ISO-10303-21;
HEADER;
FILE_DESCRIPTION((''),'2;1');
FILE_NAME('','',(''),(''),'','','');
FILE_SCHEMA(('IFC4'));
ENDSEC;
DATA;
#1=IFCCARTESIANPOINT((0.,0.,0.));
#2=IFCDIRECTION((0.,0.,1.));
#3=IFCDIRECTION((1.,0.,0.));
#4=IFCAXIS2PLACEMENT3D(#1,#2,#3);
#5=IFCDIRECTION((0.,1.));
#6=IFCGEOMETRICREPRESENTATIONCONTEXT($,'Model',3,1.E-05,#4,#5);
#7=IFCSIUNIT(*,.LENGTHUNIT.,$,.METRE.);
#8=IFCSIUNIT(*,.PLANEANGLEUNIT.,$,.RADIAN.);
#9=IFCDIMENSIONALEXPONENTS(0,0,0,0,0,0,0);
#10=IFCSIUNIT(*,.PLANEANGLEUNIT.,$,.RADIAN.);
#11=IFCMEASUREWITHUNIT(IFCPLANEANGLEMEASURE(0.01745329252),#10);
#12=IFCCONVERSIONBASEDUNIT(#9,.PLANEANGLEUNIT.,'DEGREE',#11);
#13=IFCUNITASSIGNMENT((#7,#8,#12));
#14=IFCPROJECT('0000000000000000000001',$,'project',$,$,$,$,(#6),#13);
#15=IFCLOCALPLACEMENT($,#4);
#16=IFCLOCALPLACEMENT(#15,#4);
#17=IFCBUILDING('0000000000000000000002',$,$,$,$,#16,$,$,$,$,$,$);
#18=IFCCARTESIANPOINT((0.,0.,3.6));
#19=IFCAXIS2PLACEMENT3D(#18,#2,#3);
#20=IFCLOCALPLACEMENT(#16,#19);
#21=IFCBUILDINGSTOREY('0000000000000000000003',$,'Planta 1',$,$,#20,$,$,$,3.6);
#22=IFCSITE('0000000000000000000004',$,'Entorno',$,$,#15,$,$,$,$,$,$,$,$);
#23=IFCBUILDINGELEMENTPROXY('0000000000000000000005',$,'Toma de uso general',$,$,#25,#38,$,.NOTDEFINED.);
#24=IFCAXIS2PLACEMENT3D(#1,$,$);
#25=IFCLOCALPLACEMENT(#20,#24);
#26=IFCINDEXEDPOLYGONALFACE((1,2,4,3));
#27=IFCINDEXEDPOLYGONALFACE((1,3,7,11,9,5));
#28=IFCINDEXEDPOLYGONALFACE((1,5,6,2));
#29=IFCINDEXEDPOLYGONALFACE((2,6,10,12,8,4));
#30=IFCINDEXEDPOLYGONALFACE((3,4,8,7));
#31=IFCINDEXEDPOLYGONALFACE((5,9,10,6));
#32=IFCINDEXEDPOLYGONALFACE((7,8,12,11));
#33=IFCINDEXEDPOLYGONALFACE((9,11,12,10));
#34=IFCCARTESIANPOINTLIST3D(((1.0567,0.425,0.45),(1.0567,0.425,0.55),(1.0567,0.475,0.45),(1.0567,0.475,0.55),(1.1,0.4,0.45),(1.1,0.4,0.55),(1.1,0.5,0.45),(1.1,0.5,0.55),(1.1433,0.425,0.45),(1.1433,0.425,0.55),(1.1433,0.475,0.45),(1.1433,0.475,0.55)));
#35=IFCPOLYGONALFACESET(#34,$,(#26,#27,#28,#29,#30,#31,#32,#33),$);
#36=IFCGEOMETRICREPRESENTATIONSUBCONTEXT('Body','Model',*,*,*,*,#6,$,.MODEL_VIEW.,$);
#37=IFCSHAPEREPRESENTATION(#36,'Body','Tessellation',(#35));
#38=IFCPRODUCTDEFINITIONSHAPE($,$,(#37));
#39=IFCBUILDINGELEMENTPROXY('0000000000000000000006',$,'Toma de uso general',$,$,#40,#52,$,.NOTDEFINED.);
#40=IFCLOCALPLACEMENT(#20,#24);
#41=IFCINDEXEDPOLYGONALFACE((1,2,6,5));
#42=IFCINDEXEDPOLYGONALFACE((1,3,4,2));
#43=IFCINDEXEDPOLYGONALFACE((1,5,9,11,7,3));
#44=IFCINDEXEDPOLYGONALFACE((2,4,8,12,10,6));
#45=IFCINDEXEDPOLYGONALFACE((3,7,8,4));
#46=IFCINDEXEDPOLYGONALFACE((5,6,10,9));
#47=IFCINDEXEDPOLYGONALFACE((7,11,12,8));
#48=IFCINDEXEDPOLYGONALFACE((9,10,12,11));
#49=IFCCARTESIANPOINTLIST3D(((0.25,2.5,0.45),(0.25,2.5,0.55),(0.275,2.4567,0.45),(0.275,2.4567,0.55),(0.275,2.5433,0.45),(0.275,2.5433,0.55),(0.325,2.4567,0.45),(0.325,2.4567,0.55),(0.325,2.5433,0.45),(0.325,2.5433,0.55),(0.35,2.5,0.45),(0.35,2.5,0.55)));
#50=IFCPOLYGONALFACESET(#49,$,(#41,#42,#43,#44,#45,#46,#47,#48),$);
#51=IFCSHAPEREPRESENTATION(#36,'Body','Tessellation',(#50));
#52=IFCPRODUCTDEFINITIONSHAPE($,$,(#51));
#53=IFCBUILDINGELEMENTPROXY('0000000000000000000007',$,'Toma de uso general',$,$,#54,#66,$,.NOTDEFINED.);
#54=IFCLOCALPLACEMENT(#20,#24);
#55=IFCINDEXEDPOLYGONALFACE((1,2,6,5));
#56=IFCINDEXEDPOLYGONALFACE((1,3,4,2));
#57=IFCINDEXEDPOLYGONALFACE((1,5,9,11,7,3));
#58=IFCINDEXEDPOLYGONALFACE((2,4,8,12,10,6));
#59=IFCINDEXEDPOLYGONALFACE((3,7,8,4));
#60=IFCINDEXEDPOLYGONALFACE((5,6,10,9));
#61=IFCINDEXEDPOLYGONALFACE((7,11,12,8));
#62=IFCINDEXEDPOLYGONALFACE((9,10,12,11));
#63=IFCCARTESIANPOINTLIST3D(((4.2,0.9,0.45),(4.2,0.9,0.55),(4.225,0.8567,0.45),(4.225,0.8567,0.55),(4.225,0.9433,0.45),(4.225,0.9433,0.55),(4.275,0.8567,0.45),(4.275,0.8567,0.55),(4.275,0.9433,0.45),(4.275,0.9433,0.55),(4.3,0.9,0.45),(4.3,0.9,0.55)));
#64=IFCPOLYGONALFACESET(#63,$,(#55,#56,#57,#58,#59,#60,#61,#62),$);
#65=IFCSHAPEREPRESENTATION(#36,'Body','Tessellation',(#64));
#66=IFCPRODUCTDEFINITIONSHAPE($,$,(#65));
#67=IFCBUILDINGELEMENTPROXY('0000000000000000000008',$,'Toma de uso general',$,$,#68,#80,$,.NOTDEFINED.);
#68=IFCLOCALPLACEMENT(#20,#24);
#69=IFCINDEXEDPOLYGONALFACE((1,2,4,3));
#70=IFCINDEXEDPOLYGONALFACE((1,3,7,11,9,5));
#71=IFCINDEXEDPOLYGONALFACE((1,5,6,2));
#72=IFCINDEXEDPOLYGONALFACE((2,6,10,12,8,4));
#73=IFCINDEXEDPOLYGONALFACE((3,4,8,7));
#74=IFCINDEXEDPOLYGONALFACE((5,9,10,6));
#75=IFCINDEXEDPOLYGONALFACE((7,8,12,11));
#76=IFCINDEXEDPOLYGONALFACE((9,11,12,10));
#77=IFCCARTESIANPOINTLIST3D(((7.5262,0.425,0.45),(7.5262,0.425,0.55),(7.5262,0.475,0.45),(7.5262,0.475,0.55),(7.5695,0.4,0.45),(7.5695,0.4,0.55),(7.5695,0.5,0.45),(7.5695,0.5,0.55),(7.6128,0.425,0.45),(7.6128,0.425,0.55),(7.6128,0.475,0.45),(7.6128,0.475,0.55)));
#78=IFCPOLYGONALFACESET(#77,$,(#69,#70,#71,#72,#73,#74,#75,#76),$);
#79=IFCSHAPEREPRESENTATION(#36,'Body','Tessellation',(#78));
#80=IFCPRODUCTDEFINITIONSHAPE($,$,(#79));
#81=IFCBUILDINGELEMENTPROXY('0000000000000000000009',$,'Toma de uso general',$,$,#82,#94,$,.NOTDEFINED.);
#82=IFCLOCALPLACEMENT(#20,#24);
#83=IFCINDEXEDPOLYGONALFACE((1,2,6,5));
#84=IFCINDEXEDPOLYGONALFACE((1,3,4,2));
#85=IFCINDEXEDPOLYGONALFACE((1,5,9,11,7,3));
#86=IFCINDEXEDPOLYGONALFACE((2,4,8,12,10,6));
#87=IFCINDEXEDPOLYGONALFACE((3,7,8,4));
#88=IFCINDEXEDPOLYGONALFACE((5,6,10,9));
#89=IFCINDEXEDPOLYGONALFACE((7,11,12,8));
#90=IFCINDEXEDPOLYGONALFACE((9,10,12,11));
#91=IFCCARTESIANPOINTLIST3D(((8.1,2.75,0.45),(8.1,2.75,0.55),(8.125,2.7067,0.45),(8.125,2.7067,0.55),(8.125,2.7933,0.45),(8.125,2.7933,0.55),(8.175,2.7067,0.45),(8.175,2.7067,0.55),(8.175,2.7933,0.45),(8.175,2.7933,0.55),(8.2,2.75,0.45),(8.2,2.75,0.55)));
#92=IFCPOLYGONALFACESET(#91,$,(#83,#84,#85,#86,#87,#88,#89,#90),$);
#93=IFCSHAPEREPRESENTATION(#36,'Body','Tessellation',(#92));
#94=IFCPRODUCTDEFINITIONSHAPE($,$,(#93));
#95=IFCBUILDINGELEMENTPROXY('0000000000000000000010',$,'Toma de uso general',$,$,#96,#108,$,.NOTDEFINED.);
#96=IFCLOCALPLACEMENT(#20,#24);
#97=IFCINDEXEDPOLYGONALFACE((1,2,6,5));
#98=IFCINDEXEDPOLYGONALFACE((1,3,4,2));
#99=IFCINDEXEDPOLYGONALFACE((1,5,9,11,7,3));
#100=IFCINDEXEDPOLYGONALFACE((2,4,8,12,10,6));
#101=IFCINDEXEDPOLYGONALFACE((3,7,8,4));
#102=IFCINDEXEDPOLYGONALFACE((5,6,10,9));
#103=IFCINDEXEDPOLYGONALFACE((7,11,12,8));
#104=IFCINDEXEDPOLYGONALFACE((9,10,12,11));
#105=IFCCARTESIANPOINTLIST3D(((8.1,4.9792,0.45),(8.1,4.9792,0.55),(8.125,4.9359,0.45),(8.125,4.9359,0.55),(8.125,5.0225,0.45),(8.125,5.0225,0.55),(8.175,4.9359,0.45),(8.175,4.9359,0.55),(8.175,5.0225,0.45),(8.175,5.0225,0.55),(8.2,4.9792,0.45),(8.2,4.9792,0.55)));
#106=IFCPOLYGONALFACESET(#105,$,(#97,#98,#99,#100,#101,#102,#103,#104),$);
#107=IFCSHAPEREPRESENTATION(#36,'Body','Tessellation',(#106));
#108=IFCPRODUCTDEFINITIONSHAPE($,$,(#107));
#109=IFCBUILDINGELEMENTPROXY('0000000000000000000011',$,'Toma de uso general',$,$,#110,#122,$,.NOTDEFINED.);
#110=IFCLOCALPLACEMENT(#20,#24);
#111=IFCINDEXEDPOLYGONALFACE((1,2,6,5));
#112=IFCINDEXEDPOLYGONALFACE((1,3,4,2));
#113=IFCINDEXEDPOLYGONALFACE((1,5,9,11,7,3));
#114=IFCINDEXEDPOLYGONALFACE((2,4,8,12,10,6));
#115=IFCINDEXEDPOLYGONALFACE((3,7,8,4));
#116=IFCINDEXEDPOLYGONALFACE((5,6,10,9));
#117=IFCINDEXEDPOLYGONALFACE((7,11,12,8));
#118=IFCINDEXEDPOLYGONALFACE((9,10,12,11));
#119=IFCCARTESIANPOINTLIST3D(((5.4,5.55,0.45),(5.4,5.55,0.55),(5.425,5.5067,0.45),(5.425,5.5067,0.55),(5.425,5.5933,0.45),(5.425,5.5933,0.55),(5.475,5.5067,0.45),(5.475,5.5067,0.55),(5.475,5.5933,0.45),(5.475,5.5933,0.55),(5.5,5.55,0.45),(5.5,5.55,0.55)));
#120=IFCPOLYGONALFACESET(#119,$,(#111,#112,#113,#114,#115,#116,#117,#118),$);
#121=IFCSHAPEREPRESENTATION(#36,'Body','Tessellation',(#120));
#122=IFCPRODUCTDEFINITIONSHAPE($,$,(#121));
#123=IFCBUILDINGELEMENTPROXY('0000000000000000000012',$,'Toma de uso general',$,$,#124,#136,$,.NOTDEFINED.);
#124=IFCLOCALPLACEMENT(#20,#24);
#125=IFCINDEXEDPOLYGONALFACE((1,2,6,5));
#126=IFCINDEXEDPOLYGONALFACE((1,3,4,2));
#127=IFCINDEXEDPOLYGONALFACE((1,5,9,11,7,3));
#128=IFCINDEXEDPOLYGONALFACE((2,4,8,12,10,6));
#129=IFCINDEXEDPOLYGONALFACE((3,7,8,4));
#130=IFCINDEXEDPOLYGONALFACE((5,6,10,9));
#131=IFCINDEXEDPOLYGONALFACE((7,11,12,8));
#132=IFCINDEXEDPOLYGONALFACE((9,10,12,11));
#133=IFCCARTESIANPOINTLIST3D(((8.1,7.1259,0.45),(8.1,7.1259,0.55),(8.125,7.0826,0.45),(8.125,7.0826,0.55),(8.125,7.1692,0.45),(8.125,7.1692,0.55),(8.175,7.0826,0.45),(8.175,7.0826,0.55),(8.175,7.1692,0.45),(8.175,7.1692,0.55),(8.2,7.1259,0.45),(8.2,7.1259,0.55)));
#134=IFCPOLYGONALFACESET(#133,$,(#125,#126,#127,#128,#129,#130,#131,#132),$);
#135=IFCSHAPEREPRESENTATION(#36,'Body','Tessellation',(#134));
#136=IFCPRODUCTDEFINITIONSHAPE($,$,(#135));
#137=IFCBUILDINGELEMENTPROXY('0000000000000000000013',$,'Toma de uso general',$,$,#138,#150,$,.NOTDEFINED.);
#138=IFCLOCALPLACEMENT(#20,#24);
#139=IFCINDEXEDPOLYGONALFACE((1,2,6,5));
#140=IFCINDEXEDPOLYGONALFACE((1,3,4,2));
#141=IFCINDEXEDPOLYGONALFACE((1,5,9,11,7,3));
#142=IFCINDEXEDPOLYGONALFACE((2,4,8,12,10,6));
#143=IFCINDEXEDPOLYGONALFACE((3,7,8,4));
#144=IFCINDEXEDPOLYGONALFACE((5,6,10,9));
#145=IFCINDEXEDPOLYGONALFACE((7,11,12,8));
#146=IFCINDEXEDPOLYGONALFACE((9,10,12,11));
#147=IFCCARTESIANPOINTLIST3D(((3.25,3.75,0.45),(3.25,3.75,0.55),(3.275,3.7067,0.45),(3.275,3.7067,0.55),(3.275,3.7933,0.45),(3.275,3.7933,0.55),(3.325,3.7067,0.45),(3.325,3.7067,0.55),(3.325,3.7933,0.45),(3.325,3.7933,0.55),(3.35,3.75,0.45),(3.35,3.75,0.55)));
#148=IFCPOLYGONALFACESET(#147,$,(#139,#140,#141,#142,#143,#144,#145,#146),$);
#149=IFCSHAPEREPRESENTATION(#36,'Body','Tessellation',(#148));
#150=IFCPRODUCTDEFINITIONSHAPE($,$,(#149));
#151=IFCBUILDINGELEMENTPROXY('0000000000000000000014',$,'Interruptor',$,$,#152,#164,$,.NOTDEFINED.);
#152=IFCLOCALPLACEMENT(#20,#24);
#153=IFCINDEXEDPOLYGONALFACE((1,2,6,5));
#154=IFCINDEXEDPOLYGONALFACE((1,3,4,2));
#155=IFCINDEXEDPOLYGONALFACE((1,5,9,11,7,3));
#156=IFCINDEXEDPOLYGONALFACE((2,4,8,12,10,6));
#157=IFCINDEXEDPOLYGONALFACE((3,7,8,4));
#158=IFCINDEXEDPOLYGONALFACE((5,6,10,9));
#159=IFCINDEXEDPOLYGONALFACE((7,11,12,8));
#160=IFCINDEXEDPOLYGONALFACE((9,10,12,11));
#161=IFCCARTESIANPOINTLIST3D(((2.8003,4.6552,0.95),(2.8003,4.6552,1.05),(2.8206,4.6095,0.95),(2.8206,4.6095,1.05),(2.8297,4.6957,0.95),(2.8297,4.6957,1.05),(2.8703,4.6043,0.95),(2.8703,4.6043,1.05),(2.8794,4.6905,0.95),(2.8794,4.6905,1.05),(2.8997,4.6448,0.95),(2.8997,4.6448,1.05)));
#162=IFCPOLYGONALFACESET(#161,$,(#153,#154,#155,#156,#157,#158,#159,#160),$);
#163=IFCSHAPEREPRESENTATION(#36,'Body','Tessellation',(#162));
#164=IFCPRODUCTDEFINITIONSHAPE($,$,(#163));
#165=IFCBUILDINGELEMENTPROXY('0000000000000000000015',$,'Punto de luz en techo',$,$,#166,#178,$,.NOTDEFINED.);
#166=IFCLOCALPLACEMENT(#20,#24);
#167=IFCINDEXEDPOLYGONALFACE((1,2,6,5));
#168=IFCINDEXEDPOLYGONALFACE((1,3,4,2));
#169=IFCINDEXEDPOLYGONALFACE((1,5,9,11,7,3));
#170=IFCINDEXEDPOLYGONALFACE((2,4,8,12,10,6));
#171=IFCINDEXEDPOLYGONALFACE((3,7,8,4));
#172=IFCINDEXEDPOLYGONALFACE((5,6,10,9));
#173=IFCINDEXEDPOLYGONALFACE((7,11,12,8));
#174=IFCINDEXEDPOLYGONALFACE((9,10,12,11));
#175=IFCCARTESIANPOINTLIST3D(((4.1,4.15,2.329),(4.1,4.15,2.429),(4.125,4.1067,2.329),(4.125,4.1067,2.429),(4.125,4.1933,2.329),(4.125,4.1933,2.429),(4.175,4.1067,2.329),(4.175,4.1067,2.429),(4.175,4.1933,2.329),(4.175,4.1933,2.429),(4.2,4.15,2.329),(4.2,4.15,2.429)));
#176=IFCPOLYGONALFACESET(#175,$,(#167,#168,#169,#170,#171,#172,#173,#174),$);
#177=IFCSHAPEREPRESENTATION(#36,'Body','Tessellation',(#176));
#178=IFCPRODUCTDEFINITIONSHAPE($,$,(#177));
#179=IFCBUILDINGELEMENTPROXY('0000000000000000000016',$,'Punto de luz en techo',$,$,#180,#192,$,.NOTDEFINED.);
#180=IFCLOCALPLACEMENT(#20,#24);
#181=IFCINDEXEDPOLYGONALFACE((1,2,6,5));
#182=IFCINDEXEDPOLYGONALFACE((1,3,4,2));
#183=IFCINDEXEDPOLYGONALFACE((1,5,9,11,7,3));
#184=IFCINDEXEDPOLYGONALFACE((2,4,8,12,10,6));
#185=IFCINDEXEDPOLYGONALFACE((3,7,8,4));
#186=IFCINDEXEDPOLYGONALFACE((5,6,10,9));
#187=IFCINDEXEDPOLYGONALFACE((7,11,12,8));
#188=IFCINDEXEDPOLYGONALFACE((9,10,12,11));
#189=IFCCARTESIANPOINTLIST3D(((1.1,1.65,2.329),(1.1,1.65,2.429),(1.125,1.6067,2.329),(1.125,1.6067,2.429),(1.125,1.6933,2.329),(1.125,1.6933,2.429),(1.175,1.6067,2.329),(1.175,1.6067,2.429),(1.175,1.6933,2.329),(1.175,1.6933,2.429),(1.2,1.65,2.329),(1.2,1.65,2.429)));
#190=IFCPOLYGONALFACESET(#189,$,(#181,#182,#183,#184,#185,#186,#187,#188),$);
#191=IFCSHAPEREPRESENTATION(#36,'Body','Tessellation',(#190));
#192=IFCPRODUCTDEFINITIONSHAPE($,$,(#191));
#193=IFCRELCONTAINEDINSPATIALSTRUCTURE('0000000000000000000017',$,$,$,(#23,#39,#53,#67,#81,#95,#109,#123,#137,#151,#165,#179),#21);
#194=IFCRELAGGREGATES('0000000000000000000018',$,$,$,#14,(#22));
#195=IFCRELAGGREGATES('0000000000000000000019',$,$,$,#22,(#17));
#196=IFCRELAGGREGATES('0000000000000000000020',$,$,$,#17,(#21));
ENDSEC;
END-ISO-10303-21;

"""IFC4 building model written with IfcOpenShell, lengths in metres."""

from ifc_helpers import new_model, entity, si_unit, converted_unit, direction, frame, origin_with_axes, place, context, subcontext, project, spatial, polyline, outline, extrude, source, transform, mapped, element, save


model = new_model("IFC4")

# Units and contexts
model_context = context("Model", 3, precision=1e-05, world=origin_with_axes(), true_north=direction((0.0, 1.0)))
body_context = subcontext(model_context, "Body", "Model", "MODEL_VIEW")
ifc_project = project(units=[si_unit("LENGTHUNIT", "METRE"), si_unit("PLANEANGLEUNIT", "RADIAN"), converted_unit("PLANEANGLEUNIT", "DEGREE", entity("IfcPlaneAngleMeasure", 0.01745329252), si_unit("PLANEANGLEUNIT", "RADIAN"), dimensions=[0, 0, 0, 0, 0, 0, 0])], contexts=[model_context])

# Site, building, storey
site_placement = place(None, origin_with_axes())
site = spatial("IfcSite", under=ifc_project, at=site_placement, Name="Entorno")
building_placement = place(site_placement, origin_with_axes())
building = spatial("IfcBuilding", under=site, at=building_placement)
storey_placement = place(building_placement, frame((0.0, 0.0, 3.6), z_axis=(0.0, 0.0, 1.0), x_axis=(1.0, 0.0, 0.0)))
storey = spatial("IfcBuildingStorey", under=building, at=storey_placement, Name="Planta 1", Elevation=3.6)

# Building element proxies
shared_shape_1 = source(origin_with_axes(), body_context, "Body", "SolidModel", [
    extrude(outline(polyline([(0.05, 0.0), (0.025, 0.0433), (-0.025, 0.0433), (-0.05, 0.0), (-0.025, -0.0433), (0.025, -0.0433), (0.05, 0.0)])), frame((0.0, 0.0, -0.05), z_axis=(0.0, 0.0, 1.0), x_axis=(1.0, 0.0, 0.0)), (0.0, 0.0, 1.0), 0.1),
])
proxy_1_placement = place(storey_placement, frame((0.0, 0.0, -3.6), z_axis=(0.0, 0.0, 1.0), x_axis=(1.0, 0.0, 0.0)))
element("IfcBuildingElementProxy", 1, at=proxy_1_placement, inside=storey, Name="Toma de uso general", PredefinedType="NOTDEFINED", context=body_context, shape_type="Brep", body=[
    mapped(shared_shape_1, transform((1.1, 0.45, 4.1), x_axis=(0.0, 1.0, 0.0), y_axis=(-1.0, 0.0, 0.0), z_axis=(0.0, 0.0, 1.0))),
])
proxy_2_placement = place(storey_placement, frame((0.0, 0.0, -3.6), z_axis=(0.0, 0.0, 1.0), x_axis=(1.0, 0.0, 0.0)))
element("IfcBuildingElementProxy", 2, at=proxy_2_placement, inside=storey, Name="Toma de uso general", PredefinedType="NOTDEFINED", context=body_context, shape_type="Brep", body=[
    mapped(shared_shape_1, transform((0.3, 2.5, 4.1), x_axis=(1.0, 0.0, 0.0), y_axis=(0.0, 1.0, 0.0), z_axis=(0.0, 0.0, 1.0))),
])
proxy_3_placement = place(storey_placement, frame((0.0, 0.0, -3.6), z_axis=(0.0, 0.0, 1.0), x_axis=(1.0, 0.0, 0.0)))
element("IfcBuildingElementProxy", 3, at=proxy_3_placement, inside=storey, Name="Toma de uso general", PredefinedType="NOTDEFINED", context=body_context, shape_type="Brep", body=[
    mapped(shared_shape_1, transform((4.25, 0.9, 4.1), x_axis=(1.0, 0.0, 0.0), y_axis=(0.0, 1.0, 0.0), z_axis=(0.0, 0.0, 1.0))),
])
proxy_4_placement = place(storey_placement, frame((0.0, 0.0, -3.6), z_axis=(0.0, 0.0, 1.0), x_axis=(1.0, 0.0, 0.0)))
element("IfcBuildingElementProxy", 4, at=proxy_4_placement, inside=storey, Name="Toma de uso general", PredefinedType="NOTDEFINED", context=body_context, shape_type="Brep", body=[
    mapped(shared_shape_1, transform((7.5695, 0.45, 4.1), x_axis=(0.0, 1.0, 0.0), y_axis=(-1.0, 0.0, 0.0), z_axis=(0.0, 0.0, 1.0))),
])
proxy_5_placement = place(storey_placement, frame((0.0, 0.0, -3.6), z_axis=(0.0, 0.0, 1.0), x_axis=(1.0, 0.0, 0.0)))
element("IfcBuildingElementProxy", 5, at=proxy_5_placement, inside=storey, Name="Toma de uso general", PredefinedType="NOTDEFINED", context=body_context, shape_type="Brep", body=[
    mapped(shared_shape_1, transform((8.15, 2.75, 4.1), x_axis=(-1.0, 0.0, 0.0), y_axis=(0.0, -1.0, 0.0), z_axis=(0.0, 0.0, 1.0))),
])
proxy_6_placement = place(storey_placement, frame((0.0, 0.0, -3.6), z_axis=(0.0, 0.0, 1.0), x_axis=(1.0, 0.0, 0.0)))
element("IfcBuildingElementProxy", 6, at=proxy_6_placement, inside=storey, Name="Toma de uso general", PredefinedType="NOTDEFINED", context=body_context, shape_type="Brep", body=[
    mapped(shared_shape_1, transform((8.15, 4.9792, 4.1), x_axis=(-1.0, 0.0, 0.0), y_axis=(0.0, -1.0, 0.0), z_axis=(0.0, 0.0, 1.0))),
])
proxy_7_placement = place(storey_placement, frame((0.0, 0.0, -3.6), z_axis=(0.0, 0.0, 1.0), x_axis=(1.0, 0.0, 0.0)))
element("IfcBuildingElementProxy", 7, at=proxy_7_placement, inside=storey, Name="Toma de uso general", PredefinedType="NOTDEFINED", context=body_context, shape_type="Brep", body=[
    mapped(shared_shape_1, transform((5.45, 5.55, 4.1), x_axis=(1.0, 0.0, 0.0), y_axis=(0.0, 1.0, 0.0), z_axis=(0.0, 0.0, 1.0))),
])
proxy_8_placement = place(storey_placement, frame((0.0, 0.0, -3.6), z_axis=(0.0, 0.0, 1.0), x_axis=(1.0, 0.0, 0.0)))
element("IfcBuildingElementProxy", 8, at=proxy_8_placement, inside=storey, Name="Toma de uso general", PredefinedType="NOTDEFINED", context=body_context, shape_type="Brep", body=[
    mapped(shared_shape_1, transform((8.15, 7.1259, 4.1), x_axis=(-1.0, 0.0, 0.0), y_axis=(0.0, -1.0, 0.0), z_axis=(0.0, 0.0, 1.0))),
])
proxy_9_placement = place(storey_placement, frame((0.0, 0.0, -3.6), z_axis=(0.0, 0.0, 1.0), x_axis=(1.0, 0.0, 0.0)))
element("IfcBuildingElementProxy", 9, at=proxy_9_placement, inside=storey, Name="Toma de uso general", PredefinedType="NOTDEFINED", context=body_context, shape_type="Brep", body=[
    mapped(shared_shape_1, transform((3.3, 3.75, 4.1), x_axis=(1.0, 0.0, 0.0), y_axis=(0.0, 1.0, 0.0), z_axis=(0.0, 0.0, 1.0))),
])
shared_shape_2 = source(origin_with_axes(), body_context, "Body", "SolidModel", [
    extrude(outline(polyline([(0.05, 0.0), (0.025, 0.0433), (-0.025, 0.0433), (-0.05, 0.0), (-0.025, -0.0433), (0.025, -0.0433), (0.05, 0.0)])), frame((0.0, 0.0, -0.05), z_axis=(0.0, 0.0, 1.0), x_axis=(1.0, 0.0, 0.0)), (0.0, 0.0, 1.0), 0.1),
])
proxy_10_placement = place(storey_placement, frame((0.0, 0.0, -3.6), z_axis=(0.0, 0.0, 1.0), x_axis=(1.0, 0.0, 0.0)))
element("IfcBuildingElementProxy", 10, at=proxy_10_placement, inside=storey, Name="Interruptor", PredefinedType="NOTDEFINED", context=body_context, shape_type="Brep", body=[
    mapped(shared_shape_2, transform((2.85, 4.65, 4.6), x_axis=(-0.406737, 0.913545, 0.0), y_axis=(-0.913545, -0.406737, 0.0), z_axis=(0.0, 0.0, 1.0))),
])
shared_shape_3 = source(origin_with_axes(), body_context, "Body", "SolidModel", [
    extrude(outline(polyline([(0.05, 0.0), (0.025, 0.0433), (-0.025, 0.0433), (-0.05, 0.0), (-0.025, -0.0433), (0.025, -0.0433), (0.05, 0.0)])), frame((0.0, 0.0, -0.05), z_axis=(0.0, 0.0, 1.0), x_axis=(1.0, 0.0, 0.0)), (0.0, 0.0, 1.0), 0.1),
])
proxy_11_placement = place(storey_placement, frame((0.0, 0.0, -3.6), z_axis=(0.0, 0.0, 1.0), x_axis=(1.0, 0.0, 0.0)))
element("IfcBuildingElementProxy", 11, at=proxy_11_placement, inside=storey, Name="Punto de luz en techo", PredefinedType="NOTDEFINED", context=body_context, shape_type="Brep", body=[
    mapped(shared_shape_3, transform((4.15, 4.15, 5.979), x_axis=(1.0, 0.0, 0.0), y_axis=(0.0, 1.0, 0.0), z_axis=(0.0, 0.0, 1.0))),
])
proxy_12_placement = place(storey_placement, frame((0.0, 0.0, -3.6), z_axis=(0.0, 0.0, 1.0), x_axis=(1.0, 0.0, 0.0)))
element("IfcBuildingElementProxy", 12, at=proxy_12_placement, inside=storey, Name="Punto de luz en techo", PredefinedType="NOTDEFINED", context=body_context, shape_type="Brep", body=[
    mapped(shared_shape_3, transform((1.15, 1.65, 5.979), x_axis=(1.0, 0.0, 0.0), y_axis=(0.0, 1.0, 0.0), z_axis=(0.0, 0.0, 1.0))),
])

save(model, "model.ifc")
